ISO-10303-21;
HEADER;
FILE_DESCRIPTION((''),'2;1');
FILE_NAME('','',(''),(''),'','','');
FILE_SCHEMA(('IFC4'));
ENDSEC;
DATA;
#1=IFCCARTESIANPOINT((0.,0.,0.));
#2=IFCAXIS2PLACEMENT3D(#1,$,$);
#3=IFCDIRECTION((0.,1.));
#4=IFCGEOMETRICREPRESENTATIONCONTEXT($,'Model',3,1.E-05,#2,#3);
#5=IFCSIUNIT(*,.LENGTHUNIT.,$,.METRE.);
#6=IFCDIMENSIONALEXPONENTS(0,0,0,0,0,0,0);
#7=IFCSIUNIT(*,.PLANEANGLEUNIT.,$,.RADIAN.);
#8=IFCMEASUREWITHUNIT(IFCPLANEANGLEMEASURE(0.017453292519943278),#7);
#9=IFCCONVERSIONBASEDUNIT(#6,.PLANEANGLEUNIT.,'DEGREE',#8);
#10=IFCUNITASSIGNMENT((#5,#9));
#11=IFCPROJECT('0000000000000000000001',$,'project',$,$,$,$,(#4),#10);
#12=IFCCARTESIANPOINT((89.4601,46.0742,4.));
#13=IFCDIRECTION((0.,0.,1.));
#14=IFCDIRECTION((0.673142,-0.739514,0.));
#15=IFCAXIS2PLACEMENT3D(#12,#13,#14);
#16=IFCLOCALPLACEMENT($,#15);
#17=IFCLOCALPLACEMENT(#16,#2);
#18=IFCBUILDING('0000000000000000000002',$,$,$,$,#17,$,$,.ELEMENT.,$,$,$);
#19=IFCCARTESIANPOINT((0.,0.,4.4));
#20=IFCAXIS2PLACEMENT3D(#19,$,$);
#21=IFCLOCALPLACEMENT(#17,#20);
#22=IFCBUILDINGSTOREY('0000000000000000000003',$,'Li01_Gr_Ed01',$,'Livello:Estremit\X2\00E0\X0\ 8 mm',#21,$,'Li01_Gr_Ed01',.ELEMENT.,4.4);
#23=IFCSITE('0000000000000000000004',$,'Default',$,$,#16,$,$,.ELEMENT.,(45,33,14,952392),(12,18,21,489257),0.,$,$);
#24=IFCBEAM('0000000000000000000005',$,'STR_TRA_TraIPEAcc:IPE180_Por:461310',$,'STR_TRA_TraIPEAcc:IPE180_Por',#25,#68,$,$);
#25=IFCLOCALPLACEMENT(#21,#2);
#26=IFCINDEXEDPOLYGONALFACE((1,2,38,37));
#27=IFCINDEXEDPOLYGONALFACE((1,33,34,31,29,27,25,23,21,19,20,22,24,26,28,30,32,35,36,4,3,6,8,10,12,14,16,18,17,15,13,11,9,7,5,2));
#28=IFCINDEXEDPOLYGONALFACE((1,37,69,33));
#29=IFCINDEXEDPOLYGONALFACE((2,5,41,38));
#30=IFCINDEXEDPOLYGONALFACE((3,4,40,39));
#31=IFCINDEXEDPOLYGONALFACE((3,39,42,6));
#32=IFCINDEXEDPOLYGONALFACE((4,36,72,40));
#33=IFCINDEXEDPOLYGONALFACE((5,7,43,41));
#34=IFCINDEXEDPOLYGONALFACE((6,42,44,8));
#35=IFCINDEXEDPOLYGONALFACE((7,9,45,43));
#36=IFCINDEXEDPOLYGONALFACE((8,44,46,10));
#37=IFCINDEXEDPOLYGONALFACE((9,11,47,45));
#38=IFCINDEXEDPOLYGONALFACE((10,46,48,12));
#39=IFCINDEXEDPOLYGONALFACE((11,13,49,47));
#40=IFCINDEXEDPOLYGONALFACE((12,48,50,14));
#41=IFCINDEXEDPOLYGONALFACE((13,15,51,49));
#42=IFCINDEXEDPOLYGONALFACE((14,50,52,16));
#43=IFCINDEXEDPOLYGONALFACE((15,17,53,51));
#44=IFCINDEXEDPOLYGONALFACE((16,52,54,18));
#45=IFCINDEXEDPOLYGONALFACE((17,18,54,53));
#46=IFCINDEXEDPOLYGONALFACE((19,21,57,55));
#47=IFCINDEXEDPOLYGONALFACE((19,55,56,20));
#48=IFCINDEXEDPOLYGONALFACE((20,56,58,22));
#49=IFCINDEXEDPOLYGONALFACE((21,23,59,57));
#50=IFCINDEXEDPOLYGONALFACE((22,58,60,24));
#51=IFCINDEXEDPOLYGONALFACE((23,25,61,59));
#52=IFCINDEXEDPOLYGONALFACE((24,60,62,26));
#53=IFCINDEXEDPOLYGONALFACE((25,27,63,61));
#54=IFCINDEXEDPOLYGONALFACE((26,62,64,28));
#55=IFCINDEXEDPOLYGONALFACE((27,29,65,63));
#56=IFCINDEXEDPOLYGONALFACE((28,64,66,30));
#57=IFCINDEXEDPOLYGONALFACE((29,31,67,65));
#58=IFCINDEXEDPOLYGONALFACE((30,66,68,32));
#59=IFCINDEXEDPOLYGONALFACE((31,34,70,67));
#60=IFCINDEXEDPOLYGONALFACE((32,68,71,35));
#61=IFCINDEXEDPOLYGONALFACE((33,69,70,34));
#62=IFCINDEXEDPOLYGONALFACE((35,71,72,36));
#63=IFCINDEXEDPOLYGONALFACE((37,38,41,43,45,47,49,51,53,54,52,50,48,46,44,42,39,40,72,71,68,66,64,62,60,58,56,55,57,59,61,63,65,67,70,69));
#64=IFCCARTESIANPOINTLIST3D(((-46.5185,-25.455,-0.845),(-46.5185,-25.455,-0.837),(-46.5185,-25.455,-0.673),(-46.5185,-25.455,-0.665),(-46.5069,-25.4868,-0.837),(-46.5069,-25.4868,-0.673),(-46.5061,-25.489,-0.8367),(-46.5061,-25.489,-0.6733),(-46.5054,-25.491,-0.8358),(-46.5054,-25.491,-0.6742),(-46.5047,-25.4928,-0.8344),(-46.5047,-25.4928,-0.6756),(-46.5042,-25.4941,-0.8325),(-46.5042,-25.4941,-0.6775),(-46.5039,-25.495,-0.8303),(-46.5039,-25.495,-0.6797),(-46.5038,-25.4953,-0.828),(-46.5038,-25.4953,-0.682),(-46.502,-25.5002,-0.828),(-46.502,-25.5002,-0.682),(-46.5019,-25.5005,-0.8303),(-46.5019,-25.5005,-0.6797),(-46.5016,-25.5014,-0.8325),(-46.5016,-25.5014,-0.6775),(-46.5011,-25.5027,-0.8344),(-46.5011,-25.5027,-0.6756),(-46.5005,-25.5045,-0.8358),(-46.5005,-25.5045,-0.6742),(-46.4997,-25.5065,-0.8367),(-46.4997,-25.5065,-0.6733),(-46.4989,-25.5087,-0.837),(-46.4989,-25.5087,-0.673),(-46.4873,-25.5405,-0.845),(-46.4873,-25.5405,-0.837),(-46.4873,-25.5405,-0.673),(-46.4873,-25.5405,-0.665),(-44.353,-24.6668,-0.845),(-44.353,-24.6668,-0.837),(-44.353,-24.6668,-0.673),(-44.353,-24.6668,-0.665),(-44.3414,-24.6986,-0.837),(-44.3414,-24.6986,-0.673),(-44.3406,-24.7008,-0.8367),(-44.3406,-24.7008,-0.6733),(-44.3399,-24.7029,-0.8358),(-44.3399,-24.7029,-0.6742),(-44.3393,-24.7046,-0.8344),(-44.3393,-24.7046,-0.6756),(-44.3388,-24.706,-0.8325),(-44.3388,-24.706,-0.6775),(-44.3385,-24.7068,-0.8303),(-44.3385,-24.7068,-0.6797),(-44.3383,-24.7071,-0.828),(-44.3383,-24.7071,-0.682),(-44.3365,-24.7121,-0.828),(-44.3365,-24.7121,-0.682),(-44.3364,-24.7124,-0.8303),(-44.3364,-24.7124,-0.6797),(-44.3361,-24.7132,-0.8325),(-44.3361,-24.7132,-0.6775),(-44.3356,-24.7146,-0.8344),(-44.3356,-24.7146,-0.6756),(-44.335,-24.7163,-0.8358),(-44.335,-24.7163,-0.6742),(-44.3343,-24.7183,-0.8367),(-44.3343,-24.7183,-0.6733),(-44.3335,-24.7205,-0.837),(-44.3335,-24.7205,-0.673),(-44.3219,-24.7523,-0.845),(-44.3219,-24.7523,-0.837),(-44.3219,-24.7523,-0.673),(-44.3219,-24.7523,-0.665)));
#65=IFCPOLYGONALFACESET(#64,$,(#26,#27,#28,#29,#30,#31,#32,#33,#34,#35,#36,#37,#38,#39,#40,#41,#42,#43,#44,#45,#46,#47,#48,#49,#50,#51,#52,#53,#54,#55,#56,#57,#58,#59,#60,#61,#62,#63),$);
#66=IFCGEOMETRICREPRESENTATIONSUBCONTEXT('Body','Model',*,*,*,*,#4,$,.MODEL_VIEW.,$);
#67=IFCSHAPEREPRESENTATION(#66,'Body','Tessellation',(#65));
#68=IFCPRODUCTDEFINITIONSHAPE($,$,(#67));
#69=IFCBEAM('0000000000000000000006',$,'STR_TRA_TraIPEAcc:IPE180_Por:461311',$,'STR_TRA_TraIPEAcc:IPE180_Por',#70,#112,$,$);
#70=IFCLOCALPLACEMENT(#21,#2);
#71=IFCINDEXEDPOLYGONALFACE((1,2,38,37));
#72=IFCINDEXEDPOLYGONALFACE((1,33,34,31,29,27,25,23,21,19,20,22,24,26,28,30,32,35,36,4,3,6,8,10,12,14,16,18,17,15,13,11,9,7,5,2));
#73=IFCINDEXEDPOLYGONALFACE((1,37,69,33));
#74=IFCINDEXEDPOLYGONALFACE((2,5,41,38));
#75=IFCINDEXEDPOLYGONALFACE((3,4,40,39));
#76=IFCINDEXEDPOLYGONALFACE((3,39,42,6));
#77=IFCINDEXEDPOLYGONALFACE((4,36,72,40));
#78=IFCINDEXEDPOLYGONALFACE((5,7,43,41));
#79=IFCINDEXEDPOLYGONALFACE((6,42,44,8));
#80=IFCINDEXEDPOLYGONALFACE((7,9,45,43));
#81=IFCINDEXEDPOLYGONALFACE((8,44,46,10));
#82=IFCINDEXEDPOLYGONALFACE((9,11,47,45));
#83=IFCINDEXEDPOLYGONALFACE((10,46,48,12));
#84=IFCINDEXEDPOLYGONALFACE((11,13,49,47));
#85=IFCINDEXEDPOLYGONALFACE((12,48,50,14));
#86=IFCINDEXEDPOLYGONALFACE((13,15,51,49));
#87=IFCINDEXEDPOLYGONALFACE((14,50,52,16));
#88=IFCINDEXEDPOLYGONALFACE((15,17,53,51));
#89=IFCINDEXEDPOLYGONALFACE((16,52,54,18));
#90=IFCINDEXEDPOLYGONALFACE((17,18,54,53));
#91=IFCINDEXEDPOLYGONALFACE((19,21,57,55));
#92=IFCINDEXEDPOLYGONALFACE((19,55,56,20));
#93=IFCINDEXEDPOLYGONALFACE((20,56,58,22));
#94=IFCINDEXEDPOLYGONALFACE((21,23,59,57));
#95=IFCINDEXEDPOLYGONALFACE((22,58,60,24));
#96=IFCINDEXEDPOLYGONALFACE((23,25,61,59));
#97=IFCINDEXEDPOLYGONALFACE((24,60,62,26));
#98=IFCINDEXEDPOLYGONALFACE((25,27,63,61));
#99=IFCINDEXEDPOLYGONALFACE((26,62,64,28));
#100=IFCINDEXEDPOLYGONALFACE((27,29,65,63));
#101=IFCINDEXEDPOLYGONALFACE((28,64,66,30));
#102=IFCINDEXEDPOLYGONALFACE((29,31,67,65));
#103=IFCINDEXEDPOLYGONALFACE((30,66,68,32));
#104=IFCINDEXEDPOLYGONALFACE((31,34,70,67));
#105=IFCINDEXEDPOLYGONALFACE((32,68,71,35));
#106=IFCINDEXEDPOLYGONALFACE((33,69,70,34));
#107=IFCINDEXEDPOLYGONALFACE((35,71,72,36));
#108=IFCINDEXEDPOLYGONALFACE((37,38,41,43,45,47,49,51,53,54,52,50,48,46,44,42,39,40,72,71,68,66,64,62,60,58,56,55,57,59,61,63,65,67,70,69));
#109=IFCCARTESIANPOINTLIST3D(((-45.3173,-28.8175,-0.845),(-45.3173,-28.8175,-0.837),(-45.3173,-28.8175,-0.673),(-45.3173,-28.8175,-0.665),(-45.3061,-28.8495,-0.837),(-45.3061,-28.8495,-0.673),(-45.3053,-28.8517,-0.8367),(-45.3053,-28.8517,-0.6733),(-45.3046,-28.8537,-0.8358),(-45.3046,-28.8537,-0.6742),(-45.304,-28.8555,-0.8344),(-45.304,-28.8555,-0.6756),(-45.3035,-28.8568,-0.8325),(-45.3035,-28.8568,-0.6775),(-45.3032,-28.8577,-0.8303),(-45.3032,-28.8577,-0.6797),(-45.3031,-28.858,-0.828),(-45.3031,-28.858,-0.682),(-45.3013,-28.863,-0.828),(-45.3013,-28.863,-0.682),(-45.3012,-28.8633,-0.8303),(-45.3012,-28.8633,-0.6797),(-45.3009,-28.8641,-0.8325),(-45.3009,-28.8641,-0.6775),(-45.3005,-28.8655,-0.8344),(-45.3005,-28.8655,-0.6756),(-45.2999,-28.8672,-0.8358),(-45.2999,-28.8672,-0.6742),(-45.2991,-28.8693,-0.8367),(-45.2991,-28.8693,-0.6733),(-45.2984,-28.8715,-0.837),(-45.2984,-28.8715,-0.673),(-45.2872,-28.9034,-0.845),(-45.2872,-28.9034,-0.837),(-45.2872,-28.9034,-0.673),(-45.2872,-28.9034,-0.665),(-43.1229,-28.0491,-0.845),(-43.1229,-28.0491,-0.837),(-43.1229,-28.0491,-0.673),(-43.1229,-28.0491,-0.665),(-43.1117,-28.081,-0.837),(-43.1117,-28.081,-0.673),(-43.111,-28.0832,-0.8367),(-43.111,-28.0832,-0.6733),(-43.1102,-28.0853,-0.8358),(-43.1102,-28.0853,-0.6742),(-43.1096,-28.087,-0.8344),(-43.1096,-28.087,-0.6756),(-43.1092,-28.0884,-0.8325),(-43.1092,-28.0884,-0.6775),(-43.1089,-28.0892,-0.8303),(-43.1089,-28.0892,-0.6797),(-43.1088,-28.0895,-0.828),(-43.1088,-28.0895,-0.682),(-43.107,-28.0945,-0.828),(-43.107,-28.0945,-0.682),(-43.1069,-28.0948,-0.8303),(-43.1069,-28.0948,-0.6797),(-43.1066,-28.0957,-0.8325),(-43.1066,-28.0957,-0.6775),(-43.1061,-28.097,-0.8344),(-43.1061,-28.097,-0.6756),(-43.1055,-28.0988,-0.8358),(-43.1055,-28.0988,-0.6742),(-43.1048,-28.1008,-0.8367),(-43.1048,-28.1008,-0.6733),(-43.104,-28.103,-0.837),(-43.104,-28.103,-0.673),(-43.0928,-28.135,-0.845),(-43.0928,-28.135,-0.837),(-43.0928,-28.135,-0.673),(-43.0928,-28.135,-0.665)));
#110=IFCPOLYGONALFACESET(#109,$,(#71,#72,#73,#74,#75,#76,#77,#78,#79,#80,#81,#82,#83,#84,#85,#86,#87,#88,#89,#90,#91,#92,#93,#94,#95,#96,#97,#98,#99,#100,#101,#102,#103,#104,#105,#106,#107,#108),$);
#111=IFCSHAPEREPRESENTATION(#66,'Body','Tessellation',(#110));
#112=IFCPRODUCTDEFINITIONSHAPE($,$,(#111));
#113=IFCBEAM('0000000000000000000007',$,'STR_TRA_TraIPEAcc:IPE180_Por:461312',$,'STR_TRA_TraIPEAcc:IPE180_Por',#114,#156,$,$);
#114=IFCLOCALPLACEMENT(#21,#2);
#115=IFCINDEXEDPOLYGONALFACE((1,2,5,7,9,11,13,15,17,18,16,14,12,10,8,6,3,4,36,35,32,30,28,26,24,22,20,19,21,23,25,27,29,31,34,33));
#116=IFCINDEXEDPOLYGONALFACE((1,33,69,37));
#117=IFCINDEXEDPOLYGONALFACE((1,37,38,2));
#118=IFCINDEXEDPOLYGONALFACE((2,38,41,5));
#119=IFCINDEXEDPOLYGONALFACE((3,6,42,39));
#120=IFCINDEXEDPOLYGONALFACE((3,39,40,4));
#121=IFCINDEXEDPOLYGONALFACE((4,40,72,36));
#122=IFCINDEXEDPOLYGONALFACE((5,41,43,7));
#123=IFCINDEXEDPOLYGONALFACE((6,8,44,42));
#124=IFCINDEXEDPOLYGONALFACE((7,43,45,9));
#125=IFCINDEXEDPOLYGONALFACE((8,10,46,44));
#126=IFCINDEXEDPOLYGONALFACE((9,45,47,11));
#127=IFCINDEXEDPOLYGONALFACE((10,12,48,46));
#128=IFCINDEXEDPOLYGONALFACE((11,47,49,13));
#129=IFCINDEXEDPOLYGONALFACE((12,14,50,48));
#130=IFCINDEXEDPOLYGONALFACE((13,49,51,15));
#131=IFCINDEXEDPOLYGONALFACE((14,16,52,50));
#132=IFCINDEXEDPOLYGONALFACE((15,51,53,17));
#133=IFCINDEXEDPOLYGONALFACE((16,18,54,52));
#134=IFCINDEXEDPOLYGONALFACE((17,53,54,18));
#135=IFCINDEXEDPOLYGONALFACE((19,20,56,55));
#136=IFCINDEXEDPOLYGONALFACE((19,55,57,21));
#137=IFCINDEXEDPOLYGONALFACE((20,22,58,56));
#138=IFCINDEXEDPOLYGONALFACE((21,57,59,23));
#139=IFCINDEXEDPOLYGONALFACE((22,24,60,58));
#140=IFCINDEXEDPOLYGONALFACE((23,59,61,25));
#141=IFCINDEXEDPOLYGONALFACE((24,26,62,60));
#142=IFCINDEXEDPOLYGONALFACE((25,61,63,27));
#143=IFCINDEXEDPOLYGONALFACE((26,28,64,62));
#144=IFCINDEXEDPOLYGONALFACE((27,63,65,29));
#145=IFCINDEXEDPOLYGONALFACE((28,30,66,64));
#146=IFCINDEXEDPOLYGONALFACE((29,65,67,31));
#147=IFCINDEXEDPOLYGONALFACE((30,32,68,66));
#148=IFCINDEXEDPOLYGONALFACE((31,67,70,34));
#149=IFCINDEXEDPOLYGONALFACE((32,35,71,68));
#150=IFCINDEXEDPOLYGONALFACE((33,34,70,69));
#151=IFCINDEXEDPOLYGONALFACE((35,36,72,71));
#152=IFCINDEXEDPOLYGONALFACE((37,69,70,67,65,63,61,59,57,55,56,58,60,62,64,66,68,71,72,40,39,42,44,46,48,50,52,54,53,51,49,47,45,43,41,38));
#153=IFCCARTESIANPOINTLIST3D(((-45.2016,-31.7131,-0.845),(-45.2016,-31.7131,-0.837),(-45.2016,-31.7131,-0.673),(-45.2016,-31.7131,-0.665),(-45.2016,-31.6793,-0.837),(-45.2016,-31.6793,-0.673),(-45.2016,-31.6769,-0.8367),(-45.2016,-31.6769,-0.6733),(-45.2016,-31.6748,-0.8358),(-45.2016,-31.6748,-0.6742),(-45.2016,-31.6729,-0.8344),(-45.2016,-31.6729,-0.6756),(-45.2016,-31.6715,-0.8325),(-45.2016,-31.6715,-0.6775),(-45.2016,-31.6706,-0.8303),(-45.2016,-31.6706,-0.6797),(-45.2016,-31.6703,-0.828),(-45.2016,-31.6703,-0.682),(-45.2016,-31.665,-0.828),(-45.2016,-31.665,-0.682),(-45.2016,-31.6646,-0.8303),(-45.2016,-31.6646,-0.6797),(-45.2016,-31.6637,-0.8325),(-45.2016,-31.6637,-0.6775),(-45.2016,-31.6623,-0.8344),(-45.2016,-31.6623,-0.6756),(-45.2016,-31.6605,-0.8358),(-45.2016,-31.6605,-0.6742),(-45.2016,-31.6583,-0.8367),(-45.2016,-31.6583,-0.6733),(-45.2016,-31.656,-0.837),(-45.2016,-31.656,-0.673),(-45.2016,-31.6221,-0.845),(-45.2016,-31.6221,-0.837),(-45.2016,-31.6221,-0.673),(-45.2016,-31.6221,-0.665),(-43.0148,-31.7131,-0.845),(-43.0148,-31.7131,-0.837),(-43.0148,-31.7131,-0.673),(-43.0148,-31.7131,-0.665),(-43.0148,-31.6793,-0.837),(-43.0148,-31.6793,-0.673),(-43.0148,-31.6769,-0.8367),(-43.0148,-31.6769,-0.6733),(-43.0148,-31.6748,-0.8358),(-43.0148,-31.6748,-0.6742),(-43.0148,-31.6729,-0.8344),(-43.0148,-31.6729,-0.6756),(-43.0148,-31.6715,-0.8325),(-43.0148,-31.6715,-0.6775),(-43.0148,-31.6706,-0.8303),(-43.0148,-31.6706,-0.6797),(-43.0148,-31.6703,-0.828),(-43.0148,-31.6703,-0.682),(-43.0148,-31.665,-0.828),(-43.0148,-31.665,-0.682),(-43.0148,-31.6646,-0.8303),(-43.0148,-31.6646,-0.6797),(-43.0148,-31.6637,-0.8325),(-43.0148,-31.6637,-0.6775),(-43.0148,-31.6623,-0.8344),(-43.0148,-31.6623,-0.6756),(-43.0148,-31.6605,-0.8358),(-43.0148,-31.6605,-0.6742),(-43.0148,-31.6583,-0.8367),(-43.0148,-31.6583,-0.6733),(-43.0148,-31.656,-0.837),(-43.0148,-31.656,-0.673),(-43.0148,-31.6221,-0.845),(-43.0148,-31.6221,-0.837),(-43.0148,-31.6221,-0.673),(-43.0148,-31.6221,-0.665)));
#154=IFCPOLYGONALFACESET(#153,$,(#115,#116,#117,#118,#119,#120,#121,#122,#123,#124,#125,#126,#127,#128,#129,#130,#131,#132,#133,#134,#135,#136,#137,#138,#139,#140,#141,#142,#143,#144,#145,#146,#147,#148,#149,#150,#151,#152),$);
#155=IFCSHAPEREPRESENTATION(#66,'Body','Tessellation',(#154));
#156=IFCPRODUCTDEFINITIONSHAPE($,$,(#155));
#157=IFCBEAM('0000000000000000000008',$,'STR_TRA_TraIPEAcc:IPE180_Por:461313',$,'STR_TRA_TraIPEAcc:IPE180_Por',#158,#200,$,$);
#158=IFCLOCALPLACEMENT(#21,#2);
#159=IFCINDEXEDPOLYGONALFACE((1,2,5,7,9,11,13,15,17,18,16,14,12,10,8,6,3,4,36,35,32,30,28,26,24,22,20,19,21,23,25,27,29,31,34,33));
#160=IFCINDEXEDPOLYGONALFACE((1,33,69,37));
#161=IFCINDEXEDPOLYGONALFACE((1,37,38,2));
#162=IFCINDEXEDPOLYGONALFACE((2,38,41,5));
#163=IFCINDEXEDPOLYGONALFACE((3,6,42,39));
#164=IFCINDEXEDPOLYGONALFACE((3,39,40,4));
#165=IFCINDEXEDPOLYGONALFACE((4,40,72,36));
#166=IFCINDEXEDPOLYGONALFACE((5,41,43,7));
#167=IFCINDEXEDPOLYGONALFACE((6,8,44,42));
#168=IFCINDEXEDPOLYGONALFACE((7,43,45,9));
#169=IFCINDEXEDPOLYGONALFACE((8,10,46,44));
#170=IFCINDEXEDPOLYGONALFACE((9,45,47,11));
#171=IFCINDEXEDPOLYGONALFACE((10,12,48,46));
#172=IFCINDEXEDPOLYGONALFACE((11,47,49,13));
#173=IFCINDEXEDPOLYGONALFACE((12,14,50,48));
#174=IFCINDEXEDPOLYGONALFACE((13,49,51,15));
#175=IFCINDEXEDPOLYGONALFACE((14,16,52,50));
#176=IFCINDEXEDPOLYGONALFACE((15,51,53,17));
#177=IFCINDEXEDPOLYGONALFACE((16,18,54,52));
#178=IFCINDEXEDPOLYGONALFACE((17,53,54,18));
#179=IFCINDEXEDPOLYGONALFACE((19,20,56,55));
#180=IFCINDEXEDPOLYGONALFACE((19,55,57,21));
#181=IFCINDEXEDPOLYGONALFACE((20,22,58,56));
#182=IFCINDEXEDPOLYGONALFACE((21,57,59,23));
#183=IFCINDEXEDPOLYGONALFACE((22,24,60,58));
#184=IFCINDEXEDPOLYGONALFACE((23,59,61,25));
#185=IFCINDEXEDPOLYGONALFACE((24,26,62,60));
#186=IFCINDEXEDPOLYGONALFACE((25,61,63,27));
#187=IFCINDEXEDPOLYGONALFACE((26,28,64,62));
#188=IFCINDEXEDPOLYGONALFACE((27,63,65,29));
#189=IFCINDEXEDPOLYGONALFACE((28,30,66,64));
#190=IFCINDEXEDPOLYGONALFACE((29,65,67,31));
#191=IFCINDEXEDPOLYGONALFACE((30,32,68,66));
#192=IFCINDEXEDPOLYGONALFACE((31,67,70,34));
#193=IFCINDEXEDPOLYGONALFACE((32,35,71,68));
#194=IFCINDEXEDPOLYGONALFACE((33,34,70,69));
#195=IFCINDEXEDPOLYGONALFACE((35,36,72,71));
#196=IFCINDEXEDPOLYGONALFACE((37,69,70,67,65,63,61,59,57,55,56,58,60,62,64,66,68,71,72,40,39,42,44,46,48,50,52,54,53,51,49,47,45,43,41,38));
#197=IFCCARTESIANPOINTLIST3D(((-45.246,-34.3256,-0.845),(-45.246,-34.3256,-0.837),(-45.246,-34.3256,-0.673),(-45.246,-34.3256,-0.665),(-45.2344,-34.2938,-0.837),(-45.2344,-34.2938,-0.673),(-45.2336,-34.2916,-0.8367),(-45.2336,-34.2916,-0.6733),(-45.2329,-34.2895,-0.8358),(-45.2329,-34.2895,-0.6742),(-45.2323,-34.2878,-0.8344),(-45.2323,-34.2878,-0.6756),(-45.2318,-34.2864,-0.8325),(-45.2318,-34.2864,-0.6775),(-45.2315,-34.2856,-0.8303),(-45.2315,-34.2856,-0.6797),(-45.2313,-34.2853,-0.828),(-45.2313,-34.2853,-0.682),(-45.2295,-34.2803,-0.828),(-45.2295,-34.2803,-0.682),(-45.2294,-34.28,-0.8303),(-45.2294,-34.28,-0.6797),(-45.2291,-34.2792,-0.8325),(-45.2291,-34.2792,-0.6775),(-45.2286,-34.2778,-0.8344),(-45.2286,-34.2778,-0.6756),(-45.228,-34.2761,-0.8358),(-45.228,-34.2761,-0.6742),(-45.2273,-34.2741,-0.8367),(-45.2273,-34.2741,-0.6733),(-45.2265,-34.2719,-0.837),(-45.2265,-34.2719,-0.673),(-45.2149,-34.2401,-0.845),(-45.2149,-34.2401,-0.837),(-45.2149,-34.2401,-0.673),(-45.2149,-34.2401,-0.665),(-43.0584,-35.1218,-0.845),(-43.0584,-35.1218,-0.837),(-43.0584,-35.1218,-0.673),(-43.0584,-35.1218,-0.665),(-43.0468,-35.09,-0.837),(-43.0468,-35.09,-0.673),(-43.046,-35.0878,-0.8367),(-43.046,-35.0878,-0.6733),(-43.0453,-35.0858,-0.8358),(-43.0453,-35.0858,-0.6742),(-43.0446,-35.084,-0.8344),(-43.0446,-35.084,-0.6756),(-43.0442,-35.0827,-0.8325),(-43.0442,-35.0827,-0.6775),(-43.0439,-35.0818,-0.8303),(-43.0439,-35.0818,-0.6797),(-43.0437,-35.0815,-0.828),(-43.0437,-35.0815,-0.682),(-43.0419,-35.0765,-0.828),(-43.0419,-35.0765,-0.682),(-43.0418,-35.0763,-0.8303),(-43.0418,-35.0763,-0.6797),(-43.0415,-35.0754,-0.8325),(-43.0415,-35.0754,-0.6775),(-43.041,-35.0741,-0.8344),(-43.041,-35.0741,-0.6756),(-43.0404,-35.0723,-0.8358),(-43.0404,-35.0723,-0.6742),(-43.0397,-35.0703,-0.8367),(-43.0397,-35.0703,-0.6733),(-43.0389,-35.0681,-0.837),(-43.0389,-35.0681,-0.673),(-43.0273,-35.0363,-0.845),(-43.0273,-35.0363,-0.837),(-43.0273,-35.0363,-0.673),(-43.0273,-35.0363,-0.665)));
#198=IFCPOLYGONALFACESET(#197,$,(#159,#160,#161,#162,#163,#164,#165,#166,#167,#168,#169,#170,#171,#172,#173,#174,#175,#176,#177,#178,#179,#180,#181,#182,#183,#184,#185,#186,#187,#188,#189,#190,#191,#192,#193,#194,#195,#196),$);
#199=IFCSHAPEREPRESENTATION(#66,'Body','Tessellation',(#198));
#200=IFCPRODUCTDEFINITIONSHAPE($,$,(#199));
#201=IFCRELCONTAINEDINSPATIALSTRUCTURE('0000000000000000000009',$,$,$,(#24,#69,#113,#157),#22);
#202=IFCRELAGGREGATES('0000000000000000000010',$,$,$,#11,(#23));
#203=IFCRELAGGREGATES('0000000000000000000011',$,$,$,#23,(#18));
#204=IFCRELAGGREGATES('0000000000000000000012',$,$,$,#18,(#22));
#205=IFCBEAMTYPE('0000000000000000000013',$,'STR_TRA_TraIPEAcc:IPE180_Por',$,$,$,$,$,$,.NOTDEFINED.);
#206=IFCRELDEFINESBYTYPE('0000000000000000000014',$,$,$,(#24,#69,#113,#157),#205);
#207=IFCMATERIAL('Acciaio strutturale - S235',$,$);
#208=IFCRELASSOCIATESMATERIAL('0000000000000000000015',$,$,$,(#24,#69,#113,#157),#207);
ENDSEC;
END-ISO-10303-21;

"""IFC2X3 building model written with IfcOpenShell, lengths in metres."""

from ifc_helpers import new_model, entity, si_unit, converted_unit, direction, frame, frame_2d, origin, place, context, subcontext, project, spatial, i_section, extrude, material, type_object, element, save


model = new_model("IFC2X3")

# Units and contexts
model_context = context("Model", 3, precision=1e-05, world=origin(), true_north=direction((0.0, 1.0)))
body_context = subcontext(model_context, "Body", "Model", "MODEL_VIEW")
ifc_project = project(units=[si_unit("LENGTHUNIT", "METRE"), converted_unit("PLANEANGLEUNIT", "DEGREE", entity("IfcPlaneAngleMeasure", 0.017453292519943278), si_unit("PLANEANGLEUNIT", "RADIAN"), dimensions=[0, 0, 0, 0, 0, 0, 0])], contexts=[model_context])

# Site, building, storey
site_placement = place(None, frame((89.4601, 46.0742, 4.0), z_axis=(0.0, 0.0, 1.0), x_axis=(0.673142, -0.739514, 0.0)))
site = spatial("IfcSite", under=ifc_project, at=site_placement, Name="Default", CompositionType="ELEMENT", RefLatitude=(45, 33, 14, 952392), RefLongitude=(12, 18, 21, 489257), RefElevation=0.0)
building_placement = place(site_placement, origin())
building = spatial("IfcBuilding", under=site, at=building_placement, CompositionType="ELEMENT")
storey_placement = place(building_placement, frame((0.0, 0.0, 4.4)))
storey = spatial("IfcBuildingStorey", under=building, at=storey_placement, Name="Li01_Gr_Ed01", ObjectType="Livello:Estremità 8 mm", LongName="Li01_Gr_Ed01", CompositionType="ELEMENT", Elevation=4.4)

# Beams
ifc_material_1 = material(Name="Acciaio strutturale - S235")
beam_type = type_object("IfcBeamType", Name="STR_TRA_TraIPEAcc:IPE180_Por", PredefinedType="NOTDEFINED")
beam_1_placement = place(storey_placement, frame((-46.4184, -25.467, -0.665), z_axis=(0.0, 0.0, 1.0), x_axis=(0.939693, 0.34202, 0.0)))
element("IfcBeam", 1, at=beam_1_placement, inside=storey, type_object=beam_type, material=ifc_material_1, Name="STR_TRA_TraIPEAcc:IPE180_Por:461310", ObjectType="STR_TRA_TraIPEAcc:IPE180_Por", context=body_context, shape_type="SweptSolid", body=[
    extrude(i_section(OverallWidth=0.091, OverallDepth=0.18, WebThickness=0.0053, FlangeThickness=0.008, FilletRadius=0.009, at=frame_2d((0.0, 0.0), x_axis=(0.0, 1.0))), frame((-0.0899, 0.0, -0.09), z_axis=(1.0, 0.0, 0.0), x_axis=(0.0, 0.0, -1.0)), (0.0, 0.0, 1.0), 2.3044),
])
beam_2_placement = place(storey_placement, frame((-45.3794, -28.8875, -0.665), z_axis=(0.0, 0.0, 1.0), x_axis=(0.9438, 0.330516, 0.0)))
element("IfcBeam", 2, at=beam_2_placement, inside=storey, type_object=beam_type, material=ifc_material_1, Name="STR_TRA_TraIPEAcc:IPE180_Por:461311", ObjectType="STR_TRA_TraIPEAcc:IPE180_Por", context=body_context, shape_type="SweptSolid", body=[
    extrude(i_section(OverallWidth=0.091, OverallDepth=0.18, WebThickness=0.0053, FlangeThickness=0.008, FilletRadius=0.009, at=frame_2d((0.0, 0.0), x_axis=(0.0, 1.0))), frame((0.0818, 0.0, -0.09), z_axis=(1.0, 0.0, 0.0), x_axis=(0.0, 0.0, -1.0)), (0.0, 0.0, 1.0), 2.325),
])
beam_3_placement = place(storey_placement, frame((-45.3113, -31.6676, -0.665)))
element("IfcBeam", 3, at=beam_3_placement, inside=storey, type_object=beam_type, material=ifc_material_1, Name="STR_TRA_TraIPEAcc:IPE180_Por:461312", ObjectType="STR_TRA_TraIPEAcc:IPE180_Por", context=body_context, shape_type="SweptSolid", body=[
    extrude(i_section(OverallWidth=0.091, OverallDepth=0.18, WebThickness=0.0053, FlangeThickness=0.008, FilletRadius=0.009, at=frame_2d((0.0, 0.0), x_axis=(0.0, 1.0))), frame((0.1096, 0.0, -0.09), z_axis=(1.0, 0.0, 0.0), x_axis=(0.0, 0.0, -1.0)), (0.0, 0.0, 1.0), 2.1868),
])
beam_4_placement = place(storey_placement, frame((-45.3113, -34.2534, -0.665), z_axis=(0.0, 0.0, 1.0), x_axis=(0.939692, -0.342021, 0.0)))
element("IfcBeam", 4, at=beam_4_placement, inside=storey, type_object=beam_type, material=ifc_material_1, Name="STR_TRA_TraIPEAcc:IPE180_Por:461313", ObjectType="STR_TRA_TraIPEAcc:IPE180_Por", context=body_context, shape_type="SweptSolid", body=[
    extrude(i_section(OverallWidth=0.091, OverallDepth=0.18, WebThickness=0.0053, FlangeThickness=0.008, FilletRadius=0.009, at=frame_2d((0.0, 0.0), x_axis=(0.0, 1.0))), frame((0.086, 0.0, -0.09), z_axis=(1.0, 0.0, 0.0), x_axis=(0.0, 0.0, -1.0)), (0.0, 0.0, 1.0), 2.328),
])

save(model, "model.ifc")
